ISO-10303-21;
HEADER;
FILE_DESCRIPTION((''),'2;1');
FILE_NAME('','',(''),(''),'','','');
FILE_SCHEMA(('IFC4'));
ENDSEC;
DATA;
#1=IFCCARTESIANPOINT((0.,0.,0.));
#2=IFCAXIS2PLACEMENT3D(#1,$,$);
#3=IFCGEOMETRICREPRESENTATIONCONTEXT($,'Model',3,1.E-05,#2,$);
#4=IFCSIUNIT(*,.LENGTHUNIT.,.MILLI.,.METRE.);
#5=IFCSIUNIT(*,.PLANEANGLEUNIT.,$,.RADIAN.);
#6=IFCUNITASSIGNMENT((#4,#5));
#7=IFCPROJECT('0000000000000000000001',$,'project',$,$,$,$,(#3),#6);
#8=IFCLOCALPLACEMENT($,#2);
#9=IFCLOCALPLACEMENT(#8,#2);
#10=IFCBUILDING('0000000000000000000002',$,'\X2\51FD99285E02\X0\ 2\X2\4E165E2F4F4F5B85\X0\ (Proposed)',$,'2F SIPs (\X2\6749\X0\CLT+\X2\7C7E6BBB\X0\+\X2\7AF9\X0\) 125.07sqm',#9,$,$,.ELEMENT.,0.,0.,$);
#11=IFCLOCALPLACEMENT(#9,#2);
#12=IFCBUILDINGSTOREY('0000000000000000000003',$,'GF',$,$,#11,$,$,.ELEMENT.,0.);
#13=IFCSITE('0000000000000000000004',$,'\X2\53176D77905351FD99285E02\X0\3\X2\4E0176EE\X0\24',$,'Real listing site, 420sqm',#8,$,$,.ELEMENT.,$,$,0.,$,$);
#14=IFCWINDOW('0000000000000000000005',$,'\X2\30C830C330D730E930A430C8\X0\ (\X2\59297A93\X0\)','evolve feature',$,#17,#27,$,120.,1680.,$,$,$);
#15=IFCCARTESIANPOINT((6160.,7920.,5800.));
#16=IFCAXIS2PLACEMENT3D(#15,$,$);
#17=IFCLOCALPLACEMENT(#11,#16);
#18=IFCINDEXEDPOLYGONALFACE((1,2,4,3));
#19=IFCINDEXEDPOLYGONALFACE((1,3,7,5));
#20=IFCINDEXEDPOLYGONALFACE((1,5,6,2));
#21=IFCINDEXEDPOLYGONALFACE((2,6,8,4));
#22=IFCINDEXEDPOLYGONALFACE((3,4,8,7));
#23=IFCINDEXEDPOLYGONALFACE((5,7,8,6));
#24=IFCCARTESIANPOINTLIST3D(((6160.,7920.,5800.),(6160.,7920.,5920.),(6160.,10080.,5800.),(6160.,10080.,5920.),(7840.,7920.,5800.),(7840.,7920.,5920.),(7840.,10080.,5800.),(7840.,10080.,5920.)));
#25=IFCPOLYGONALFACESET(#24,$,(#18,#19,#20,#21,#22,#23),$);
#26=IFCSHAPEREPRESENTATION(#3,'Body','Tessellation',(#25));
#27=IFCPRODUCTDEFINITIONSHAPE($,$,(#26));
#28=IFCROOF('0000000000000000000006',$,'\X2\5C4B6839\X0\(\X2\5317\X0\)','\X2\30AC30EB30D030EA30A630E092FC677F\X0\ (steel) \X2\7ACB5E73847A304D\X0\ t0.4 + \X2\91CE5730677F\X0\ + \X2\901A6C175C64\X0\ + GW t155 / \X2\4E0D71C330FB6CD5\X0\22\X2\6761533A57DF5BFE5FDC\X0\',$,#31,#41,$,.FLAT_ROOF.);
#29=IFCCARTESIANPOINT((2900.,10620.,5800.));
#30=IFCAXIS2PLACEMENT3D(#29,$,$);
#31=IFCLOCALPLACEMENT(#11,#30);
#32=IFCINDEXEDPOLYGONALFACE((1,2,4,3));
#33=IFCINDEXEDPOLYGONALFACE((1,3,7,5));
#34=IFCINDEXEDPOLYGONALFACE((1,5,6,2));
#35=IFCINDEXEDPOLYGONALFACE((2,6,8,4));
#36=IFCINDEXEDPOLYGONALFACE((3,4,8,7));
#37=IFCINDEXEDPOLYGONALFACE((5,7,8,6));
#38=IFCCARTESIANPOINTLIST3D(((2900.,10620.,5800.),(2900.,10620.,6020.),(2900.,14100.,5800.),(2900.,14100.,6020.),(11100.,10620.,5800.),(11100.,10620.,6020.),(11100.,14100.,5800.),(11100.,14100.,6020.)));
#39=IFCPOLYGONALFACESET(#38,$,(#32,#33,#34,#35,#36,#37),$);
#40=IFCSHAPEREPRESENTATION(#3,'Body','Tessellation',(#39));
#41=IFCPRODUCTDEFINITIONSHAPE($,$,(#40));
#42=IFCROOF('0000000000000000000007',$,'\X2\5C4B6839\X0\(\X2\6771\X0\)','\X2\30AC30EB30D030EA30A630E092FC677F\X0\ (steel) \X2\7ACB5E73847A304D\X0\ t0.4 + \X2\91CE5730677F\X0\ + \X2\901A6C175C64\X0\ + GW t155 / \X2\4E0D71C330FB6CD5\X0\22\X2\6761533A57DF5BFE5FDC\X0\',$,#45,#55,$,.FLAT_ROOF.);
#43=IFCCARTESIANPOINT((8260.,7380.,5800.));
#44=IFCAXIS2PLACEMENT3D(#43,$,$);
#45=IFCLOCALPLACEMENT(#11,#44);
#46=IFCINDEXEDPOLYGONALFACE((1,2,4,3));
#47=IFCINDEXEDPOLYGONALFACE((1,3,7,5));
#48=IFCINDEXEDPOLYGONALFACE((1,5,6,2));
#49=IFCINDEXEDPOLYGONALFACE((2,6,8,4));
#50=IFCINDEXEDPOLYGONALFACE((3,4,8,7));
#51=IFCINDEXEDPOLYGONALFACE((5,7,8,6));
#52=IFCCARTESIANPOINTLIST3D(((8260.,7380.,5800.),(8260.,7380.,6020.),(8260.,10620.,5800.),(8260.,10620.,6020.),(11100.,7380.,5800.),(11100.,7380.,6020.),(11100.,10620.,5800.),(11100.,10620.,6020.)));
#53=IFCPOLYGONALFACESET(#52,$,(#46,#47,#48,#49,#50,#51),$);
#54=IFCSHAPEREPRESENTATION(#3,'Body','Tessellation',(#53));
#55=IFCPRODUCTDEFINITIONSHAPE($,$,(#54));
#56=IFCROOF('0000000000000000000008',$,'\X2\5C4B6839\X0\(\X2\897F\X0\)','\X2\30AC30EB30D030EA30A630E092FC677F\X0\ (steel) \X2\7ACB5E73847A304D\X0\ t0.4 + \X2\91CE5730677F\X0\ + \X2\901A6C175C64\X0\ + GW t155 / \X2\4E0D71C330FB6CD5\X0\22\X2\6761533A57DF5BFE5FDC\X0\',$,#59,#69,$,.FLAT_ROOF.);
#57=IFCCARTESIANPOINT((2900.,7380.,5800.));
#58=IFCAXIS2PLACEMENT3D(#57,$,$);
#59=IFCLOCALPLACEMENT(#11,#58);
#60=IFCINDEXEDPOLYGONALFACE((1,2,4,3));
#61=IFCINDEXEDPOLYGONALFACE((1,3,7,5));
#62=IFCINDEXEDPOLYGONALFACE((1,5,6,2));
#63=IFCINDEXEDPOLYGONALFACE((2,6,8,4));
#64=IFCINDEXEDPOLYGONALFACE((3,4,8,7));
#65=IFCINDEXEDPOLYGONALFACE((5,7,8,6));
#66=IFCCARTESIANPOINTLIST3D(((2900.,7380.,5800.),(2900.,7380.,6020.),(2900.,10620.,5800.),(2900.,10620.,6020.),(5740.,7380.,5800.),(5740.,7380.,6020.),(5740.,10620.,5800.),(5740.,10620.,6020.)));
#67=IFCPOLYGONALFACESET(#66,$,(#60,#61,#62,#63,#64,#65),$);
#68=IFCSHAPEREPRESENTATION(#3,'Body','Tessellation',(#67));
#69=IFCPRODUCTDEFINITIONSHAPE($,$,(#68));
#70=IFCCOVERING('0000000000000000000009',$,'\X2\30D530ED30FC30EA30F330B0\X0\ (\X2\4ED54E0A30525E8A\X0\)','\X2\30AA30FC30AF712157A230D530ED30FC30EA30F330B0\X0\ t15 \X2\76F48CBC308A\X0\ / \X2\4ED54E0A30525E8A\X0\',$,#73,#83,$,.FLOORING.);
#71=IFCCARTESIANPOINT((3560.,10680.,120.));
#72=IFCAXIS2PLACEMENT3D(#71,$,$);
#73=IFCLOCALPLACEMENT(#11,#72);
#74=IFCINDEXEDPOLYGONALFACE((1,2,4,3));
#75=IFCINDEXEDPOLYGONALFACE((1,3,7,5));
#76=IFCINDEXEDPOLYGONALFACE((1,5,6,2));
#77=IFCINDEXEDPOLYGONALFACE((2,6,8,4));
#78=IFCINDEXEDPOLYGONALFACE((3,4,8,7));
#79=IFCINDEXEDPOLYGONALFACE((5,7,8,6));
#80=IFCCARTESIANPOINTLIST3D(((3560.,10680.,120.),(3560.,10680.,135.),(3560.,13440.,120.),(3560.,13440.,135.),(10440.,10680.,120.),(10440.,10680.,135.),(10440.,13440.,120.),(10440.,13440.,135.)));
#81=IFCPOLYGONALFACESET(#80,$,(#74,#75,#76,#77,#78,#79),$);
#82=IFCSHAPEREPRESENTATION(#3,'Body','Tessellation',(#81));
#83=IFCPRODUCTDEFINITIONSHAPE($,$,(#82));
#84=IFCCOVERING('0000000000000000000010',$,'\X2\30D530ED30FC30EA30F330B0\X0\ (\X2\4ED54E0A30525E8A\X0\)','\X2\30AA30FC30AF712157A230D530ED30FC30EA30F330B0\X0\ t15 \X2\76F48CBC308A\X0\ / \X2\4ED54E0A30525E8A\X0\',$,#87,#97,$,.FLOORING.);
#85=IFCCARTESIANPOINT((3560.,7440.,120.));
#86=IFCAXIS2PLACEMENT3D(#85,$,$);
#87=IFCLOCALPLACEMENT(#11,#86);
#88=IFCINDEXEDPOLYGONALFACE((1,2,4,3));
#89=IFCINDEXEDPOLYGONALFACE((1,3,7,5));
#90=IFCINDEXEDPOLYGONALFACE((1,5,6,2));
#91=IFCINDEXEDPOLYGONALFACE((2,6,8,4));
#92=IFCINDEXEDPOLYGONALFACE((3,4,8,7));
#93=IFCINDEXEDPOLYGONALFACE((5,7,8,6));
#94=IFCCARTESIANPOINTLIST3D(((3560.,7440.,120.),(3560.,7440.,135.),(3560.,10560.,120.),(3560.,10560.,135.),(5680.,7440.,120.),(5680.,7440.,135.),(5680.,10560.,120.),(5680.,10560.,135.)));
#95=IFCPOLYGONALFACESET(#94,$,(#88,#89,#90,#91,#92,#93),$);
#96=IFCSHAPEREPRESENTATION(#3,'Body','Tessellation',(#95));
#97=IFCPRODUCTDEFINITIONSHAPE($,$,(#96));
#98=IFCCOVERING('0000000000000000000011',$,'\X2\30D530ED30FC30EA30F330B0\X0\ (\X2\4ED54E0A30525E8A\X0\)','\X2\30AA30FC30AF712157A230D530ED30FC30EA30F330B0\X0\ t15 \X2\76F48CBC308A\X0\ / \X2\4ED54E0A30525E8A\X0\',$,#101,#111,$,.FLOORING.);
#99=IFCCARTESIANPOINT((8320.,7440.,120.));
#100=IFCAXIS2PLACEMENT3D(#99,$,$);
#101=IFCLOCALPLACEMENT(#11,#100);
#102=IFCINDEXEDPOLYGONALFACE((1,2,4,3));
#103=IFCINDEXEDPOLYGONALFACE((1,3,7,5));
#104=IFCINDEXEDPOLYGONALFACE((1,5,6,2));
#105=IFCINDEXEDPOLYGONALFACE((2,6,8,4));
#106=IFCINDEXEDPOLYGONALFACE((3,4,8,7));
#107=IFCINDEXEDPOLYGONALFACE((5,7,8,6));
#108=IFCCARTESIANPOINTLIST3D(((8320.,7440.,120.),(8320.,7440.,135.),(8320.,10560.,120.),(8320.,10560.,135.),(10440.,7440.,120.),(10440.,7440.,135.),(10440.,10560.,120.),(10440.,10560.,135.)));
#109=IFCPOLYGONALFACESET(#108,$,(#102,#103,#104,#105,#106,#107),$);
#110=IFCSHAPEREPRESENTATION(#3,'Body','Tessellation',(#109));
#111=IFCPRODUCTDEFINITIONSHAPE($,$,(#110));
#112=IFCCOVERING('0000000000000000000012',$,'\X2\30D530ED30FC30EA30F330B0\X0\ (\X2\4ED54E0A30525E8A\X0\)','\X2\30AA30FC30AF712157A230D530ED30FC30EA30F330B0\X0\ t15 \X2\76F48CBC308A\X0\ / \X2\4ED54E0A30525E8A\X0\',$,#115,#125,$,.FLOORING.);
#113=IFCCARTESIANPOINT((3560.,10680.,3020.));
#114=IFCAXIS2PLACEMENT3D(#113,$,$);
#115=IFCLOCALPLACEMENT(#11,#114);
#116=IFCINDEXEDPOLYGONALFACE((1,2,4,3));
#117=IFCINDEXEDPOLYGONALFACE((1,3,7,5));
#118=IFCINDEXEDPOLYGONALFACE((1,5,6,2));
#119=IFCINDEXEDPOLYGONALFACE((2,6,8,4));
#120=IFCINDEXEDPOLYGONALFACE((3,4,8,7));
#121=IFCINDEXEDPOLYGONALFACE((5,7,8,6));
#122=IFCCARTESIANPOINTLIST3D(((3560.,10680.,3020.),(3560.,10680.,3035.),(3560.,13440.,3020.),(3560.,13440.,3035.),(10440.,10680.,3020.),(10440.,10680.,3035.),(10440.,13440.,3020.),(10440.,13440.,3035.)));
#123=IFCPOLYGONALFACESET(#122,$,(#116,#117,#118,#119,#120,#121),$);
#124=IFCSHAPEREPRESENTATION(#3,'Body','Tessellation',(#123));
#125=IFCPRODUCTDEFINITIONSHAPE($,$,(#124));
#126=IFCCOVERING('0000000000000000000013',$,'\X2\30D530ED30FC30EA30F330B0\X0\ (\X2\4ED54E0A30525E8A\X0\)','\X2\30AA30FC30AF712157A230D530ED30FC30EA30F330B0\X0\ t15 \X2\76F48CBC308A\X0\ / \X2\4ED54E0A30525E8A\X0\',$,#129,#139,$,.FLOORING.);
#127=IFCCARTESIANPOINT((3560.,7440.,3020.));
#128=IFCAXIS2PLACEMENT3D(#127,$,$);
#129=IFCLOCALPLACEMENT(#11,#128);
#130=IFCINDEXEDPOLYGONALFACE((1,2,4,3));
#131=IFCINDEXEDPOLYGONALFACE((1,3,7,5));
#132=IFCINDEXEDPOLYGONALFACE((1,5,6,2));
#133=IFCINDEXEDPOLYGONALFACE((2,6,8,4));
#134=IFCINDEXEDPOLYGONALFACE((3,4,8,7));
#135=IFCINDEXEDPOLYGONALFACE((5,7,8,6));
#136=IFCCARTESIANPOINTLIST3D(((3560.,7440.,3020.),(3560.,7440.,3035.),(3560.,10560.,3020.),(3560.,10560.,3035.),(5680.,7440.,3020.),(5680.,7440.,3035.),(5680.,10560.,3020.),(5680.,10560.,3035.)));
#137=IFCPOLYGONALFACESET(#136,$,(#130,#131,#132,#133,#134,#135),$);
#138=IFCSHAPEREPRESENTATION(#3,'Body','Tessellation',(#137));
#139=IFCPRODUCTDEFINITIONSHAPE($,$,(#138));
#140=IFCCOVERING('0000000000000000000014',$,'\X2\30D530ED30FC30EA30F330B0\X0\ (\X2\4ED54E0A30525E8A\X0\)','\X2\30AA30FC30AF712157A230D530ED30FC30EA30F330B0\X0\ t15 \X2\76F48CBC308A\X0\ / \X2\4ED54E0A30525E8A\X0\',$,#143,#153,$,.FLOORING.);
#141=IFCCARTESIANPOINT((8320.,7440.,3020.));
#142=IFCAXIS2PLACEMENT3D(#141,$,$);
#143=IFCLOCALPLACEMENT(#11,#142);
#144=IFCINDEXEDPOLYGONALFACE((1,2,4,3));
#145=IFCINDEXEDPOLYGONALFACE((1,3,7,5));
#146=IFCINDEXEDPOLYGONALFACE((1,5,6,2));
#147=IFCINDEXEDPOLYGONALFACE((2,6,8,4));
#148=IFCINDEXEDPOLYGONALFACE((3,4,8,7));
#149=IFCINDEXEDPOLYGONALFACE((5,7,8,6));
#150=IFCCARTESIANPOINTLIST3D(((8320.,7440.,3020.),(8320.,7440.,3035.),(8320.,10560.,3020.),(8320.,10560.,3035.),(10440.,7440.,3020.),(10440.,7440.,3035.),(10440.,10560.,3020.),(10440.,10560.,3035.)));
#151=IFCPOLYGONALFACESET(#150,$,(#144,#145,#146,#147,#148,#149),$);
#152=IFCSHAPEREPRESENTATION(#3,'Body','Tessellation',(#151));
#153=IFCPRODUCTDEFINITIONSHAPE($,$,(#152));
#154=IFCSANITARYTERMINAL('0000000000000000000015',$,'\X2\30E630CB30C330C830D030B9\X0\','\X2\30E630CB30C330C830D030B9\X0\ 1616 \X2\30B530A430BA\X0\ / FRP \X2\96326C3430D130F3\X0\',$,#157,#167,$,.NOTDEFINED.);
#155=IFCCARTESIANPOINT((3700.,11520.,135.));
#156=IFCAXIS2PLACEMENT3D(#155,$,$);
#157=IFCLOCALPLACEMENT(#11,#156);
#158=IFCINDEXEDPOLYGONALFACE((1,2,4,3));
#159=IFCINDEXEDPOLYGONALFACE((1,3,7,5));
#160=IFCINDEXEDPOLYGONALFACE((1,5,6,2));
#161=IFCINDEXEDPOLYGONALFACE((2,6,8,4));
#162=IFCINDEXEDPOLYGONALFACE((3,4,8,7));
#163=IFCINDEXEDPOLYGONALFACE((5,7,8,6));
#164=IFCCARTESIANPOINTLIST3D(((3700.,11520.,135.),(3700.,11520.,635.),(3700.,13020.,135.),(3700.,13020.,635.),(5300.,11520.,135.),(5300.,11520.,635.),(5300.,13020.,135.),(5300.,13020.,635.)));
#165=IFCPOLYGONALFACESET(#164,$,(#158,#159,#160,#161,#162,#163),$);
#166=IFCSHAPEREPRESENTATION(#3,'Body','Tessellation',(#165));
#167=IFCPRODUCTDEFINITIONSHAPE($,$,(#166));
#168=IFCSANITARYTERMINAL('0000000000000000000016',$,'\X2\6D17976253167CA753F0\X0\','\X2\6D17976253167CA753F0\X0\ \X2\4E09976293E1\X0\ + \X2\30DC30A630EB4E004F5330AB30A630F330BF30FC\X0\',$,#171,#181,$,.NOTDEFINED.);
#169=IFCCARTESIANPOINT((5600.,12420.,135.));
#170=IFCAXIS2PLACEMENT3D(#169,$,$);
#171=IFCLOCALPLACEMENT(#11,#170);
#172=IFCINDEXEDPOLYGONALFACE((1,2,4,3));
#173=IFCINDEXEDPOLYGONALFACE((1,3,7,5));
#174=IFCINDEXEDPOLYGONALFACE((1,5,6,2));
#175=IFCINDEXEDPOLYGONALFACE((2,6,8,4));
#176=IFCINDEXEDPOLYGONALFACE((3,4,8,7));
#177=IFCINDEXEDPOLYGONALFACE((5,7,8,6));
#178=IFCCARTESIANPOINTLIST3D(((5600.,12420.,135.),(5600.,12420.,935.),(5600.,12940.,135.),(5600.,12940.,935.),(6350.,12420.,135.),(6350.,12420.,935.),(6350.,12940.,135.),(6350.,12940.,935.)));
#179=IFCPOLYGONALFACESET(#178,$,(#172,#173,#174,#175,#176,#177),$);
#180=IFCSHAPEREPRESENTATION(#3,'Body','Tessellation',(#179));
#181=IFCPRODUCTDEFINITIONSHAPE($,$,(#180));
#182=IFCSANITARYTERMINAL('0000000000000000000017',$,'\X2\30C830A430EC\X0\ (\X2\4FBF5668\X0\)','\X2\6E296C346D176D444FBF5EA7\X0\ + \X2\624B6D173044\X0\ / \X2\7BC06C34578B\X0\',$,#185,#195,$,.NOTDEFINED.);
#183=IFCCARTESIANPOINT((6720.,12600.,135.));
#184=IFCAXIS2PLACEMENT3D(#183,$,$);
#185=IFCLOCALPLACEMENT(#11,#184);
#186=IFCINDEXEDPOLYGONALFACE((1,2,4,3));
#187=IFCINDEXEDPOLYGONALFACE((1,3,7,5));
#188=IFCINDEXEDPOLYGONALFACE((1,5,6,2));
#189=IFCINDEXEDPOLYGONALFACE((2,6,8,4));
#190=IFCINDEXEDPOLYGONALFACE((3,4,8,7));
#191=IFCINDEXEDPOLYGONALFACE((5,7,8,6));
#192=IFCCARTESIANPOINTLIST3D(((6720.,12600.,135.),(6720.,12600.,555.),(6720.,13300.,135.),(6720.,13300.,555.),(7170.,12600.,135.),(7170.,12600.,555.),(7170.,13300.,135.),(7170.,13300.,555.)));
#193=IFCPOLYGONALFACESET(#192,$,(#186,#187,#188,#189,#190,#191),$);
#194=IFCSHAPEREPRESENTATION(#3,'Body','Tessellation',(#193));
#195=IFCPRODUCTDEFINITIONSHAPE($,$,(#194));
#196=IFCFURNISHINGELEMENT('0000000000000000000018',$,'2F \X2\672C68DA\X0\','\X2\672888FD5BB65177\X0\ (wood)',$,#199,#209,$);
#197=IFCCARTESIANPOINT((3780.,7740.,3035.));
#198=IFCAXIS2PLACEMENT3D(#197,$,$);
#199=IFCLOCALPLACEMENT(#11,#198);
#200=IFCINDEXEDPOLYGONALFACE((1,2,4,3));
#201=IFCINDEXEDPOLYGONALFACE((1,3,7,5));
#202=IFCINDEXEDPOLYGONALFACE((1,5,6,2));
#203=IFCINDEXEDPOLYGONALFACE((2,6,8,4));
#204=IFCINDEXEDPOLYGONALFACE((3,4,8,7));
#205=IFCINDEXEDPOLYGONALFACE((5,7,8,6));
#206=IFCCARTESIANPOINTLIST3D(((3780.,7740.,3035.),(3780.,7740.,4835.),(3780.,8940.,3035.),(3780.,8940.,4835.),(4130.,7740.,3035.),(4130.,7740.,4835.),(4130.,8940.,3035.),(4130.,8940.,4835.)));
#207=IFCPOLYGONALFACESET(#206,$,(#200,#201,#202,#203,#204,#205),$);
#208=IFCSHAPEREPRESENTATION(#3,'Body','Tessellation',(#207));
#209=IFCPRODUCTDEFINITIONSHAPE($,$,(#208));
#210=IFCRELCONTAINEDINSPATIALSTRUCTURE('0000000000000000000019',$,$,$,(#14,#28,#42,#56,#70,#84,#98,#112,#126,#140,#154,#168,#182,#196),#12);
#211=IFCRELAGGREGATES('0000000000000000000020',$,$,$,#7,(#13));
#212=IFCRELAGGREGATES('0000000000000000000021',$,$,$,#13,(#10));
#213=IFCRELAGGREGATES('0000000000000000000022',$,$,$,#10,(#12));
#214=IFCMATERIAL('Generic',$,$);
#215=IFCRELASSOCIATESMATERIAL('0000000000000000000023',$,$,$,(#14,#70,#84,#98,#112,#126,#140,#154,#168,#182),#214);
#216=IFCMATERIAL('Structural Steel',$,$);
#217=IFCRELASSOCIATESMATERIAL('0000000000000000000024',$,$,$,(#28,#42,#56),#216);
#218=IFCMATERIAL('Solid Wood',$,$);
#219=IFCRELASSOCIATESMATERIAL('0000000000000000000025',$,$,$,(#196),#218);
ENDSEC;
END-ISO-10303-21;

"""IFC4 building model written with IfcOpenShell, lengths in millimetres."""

from ifc_helpers import new_model, si_unit, frame, frame_2d, origin, place, context, project, spatial, rectangle, extrude, material, element, save


model = new_model("IFC4")

# Units and contexts
model_context = context("Model", 3, precision=1e-05, world=origin())
ifc_project = project(units=[si_unit("LENGTHUNIT", "METRE", prefix="MILLI"), si_unit("PLANEANGLEUNIT", "RADIAN")], contexts=[model_context])

# Site, building, storey
site_placement = place(None, origin())
site = spatial("IfcSite", under=ifc_project, at=site_placement, Name="北海道函館市3丁目24", ObjectType="Real listing site, 420sqm", CompositionType="ELEMENT", RefElevation=0.0)
building_placement = place(site_placement, origin())
building = spatial("IfcBuilding", under=site, at=building_placement, Name="函館市 2世帯住宅 (Proposed)", ObjectType="2F SIPs (杉CLT+籾殻+竹) 125.07sqm", CompositionType="ELEMENT", ElevationOfRefHeight=0.0, ElevationOfTerrain=0.0)
storey_placement = place(building_placement, origin())
storey = spatial("IfcBuildingStorey", under=building, at=storey_placement, Name="GF", CompositionType="ELEMENT", Elevation=0.0)

# Shared definitions
ifc_material_1 = material(Name="Solid Wood")

# Window
ifc_material_2 = material(Name="Generic")
window_1_placement = place(storey_placement, frame((6160.0, 7920.0, 5800.0)))
element("IfcWindow", 1, at=window_1_placement, inside=storey, material=ifc_material_2, Name="トップライト (天窓)", Description="evolve feature", OverallHeight=120.0, OverallWidth=1680.0, context=model_context, shape_type="SweptSolid", body=[
    extrude(rectangle(XDim=1680.0, YDim=2160.0, at=frame_2d((840.0, 1080.0))), frame((6160.0, 7920.0, 5800.0)), (0.0, 0.0, 1.0), 120.0),
])

# Roofs
ifc_material_3 = material(Name="Structural Steel")
roof_1_placement = place(storey_placement, frame((2900.0, 10620.0, 5800.0)))
element("IfcRoof", 2, at=roof_1_placement, inside=storey, material=ifc_material_3, Name="屋根(北)", Description="ガルバリウム鋼板 (steel) 立平葺き t0.4 + 野地板 + 通気層 + GW t155 / 不燃・法22条区域対応", PredefinedType="FLAT_ROOF", context=model_context, shape_type="SweptSolid", body=[
    extrude(rectangle(XDim=8200.0, YDim=3480.0, at=frame_2d((4100.0, 1740.0))), frame((2900.0, 10620.0, 5800.0)), (0.0, 0.0, 1.0), 220.0),
])
roof_2_placement = place(storey_placement, frame((8260.0, 7380.0, 5800.0)))
element("IfcRoof", 3, at=roof_2_placement, inside=storey, material=ifc_material_3, Name="屋根(東)", Description="ガルバリウム鋼板 (steel) 立平葺き t0.4 + 野地板 + 通気層 + GW t155 / 不燃・法22条区域対応", PredefinedType="FLAT_ROOF", context=model_context, shape_type="SweptSolid", body=[
    extrude(rectangle(XDim=2840.0, YDim=3240.0, at=frame_2d((1420.0, 1620.0))), frame((8260.0, 7380.0, 5800.0)), (0.0, 0.0, 1.0), 220.0),
])
roof_3_placement = place(storey_placement, frame((2900.0, 7380.0, 5800.0)))
element("IfcRoof", 4, at=roof_3_placement, inside=storey, material=ifc_material_3, Name="屋根(西)", Description="ガルバリウム鋼板 (steel) 立平葺き t0.4 + 野地板 + 通気層 + GW t155 / 不燃・法22条区域対応", PredefinedType="FLAT_ROOF", context=model_context, shape_type="SweptSolid", body=[
    extrude(rectangle(XDim=2840.0, YDim=3240.0, at=frame_2d((1420.0, 1620.0))), frame((2900.0, 7380.0, 5800.0)), (0.0, 0.0, 1.0), 220.0),
])

# Coverings
covering_1_placement = place(storey_placement, frame((3560.0, 10680.0, 120.0)))
element("IfcCovering", 5, at=covering_1_placement, inside=storey, material=ifc_material_2, Name="フローリング (仕上げ床)", Description="オーク無垢フローリング t15 直貼り / 仕上げ床", PredefinedType="FLOORING", context=model_context, shape_type="SweptSolid", body=[
    extrude(rectangle(XDim=6880.0, YDim=2760.0, at=frame_2d((3440.0, 1380.0))), frame((3560.0, 10680.0, 120.0)), (0.0, 0.0, 1.0), 15.0),
])
covering_2_placement = place(storey_placement, frame((3560.0, 7440.0, 120.0)))
element("IfcCovering", 6, at=covering_2_placement, inside=storey, material=ifc_material_2, Name="フローリング (仕上げ床)", Description="オーク無垢フローリング t15 直貼り / 仕上げ床", PredefinedType="FLOORING", context=model_context, shape_type="SweptSolid", body=[
    extrude(rectangle(XDim=2120.0, YDim=3120.0, at=frame_2d((1060.0, 1560.0))), frame((3560.0, 7440.0, 120.0)), (0.0, 0.0, 1.0), 15.0),
])
covering_3_placement = place(storey_placement, frame((8320.0, 7440.0, 120.0)))
element("IfcCovering", 7, at=covering_3_placement, inside=storey, material=ifc_material_2, Name="フローリング (仕上げ床)", Description="オーク無垢フローリング t15 直貼り / 仕上げ床", PredefinedType="FLOORING", context=model_context, shape_type="SweptSolid", body=[
    extrude(rectangle(XDim=2120.0, YDim=3120.0, at=frame_2d((1060.0, 1560.0))), frame((8320.0, 7440.0, 120.0)), (0.0, 0.0, 1.0), 15.0),
])
covering_4_placement = place(storey_placement, frame((3560.0, 10680.0, 3020.0)))
element("IfcCovering", 8, at=covering_4_placement, inside=storey, material=ifc_material_2, Name="フローリング (仕上げ床)", Description="オーク無垢フローリング t15 直貼り / 仕上げ床", PredefinedType="FLOORING", context=model_context, shape_type="SweptSolid", body=[
    extrude(rectangle(XDim=6880.0, YDim=2760.0, at=frame_2d((3440.0, 1380.0))), frame((3560.0, 10680.0, 3020.0)), (0.0, 0.0, 1.0), 15.0),
])
covering_5_placement = place(storey_placement, frame((3560.0, 7440.0, 3020.0)))
element("IfcCovering", 9, at=covering_5_placement, inside=storey, material=ifc_material_2, Name="フローリング (仕上げ床)", Description="オーク無垢フローリング t15 直貼り / 仕上げ床", PredefinedType="FLOORING", context=model_context, shape_type="SweptSolid", body=[
    extrude(rectangle(XDim=2120.0, YDim=3120.0, at=frame_2d((1060.0, 1560.0))), frame((3560.0, 7440.0, 3020.0)), (0.0, 0.0, 1.0), 15.0),
])
covering_6_placement = place(storey_placement, frame((8320.0, 7440.0, 3020.0)))
element("IfcCovering", 10, at=covering_6_placement, inside=storey, material=ifc_material_2, Name="フローリング (仕上げ床)", Description="オーク無垢フローリング t15 直貼り / 仕上げ床", PredefinedType="FLOORING", context=model_context, shape_type="SweptSolid", body=[
    extrude(rectangle(XDim=2120.0, YDim=3120.0, at=frame_2d((1060.0, 1560.0))), frame((8320.0, 7440.0, 3020.0)), (0.0, 0.0, 1.0), 15.0),
])

# Sanitary terminals
sanitary_terminal_1_placement = place(storey_placement, frame((3700.0, 11520.0, 135.0)))
element("IfcSanitaryTerminal", 11, at=sanitary_terminal_1_placement, inside=storey, material=ifc_material_2, Name="ユニットバス", Description="ユニットバス 1616 サイズ / FRP 防水パン", PredefinedType="NOTDEFINED", context=model_context, shape_type="SweptSolid", body=[
    extrude(rectangle(XDim=1600.0, YDim=1500.0, at=frame_2d((800.0, 750.0))), frame((3700.0, 11520.0, 135.0)), (0.0, 0.0, 1.0), 500.0),
])
sanitary_terminal_2_placement = place(storey_placement, frame((5600.0, 12420.0, 135.0)))
element("IfcSanitaryTerminal", 12, at=sanitary_terminal_2_placement, inside=storey, material=ifc_material_2, Name="洗面化粧台", Description="洗面化粧台 三面鏡 + ボウル一体カウンター", PredefinedType="NOTDEFINED", context=model_context, shape_type="SweptSolid", body=[
    extrude(rectangle(XDim=750.0, YDim=520.0, at=frame_2d((375.0, 260.0))), frame((5600.0, 12420.0, 135.0)), (0.0, 0.0, 1.0), 800.0),
])
sanitary_terminal_3_placement = place(storey_placement, frame((6720.0, 12600.0, 135.0)))
element("IfcSanitaryTerminal", 13, at=sanitary_terminal_3_placement, inside=storey, material=ifc_material_2, Name="トイレ (便器)", Description="温水洗浄便座 + 手洗い / 節水型", PredefinedType="NOTDEFINED", context=model_context, shape_type="SweptSolid", body=[
    extrude(rectangle(XDim=450.0, YDim=700.0, at=frame_2d((225.0, 350.0))), frame((6720.0, 12600.0, 135.0)), (0.0, 0.0, 1.0), 420.0),
])

# Furnishing element
furnishing_placement = place(storey_placement, frame((3780.0, 7740.0, 3035.0)))
element("IfcFurnishingElement", 14, at=furnishing_placement, inside=storey, material=ifc_material_1, Name="2F 本棚", Description="木製家具 (wood)", context=model_context, shape_type="SweptSolid", body=[
    extrude(rectangle(XDim=350.0, YDim=1200.0, at=frame_2d((175.0, 600.0))), frame((3780.0, 7740.0, 3035.0)), (0.0, 0.0, 1.0), 1800.0),
])

save(model, "model.ifc")
